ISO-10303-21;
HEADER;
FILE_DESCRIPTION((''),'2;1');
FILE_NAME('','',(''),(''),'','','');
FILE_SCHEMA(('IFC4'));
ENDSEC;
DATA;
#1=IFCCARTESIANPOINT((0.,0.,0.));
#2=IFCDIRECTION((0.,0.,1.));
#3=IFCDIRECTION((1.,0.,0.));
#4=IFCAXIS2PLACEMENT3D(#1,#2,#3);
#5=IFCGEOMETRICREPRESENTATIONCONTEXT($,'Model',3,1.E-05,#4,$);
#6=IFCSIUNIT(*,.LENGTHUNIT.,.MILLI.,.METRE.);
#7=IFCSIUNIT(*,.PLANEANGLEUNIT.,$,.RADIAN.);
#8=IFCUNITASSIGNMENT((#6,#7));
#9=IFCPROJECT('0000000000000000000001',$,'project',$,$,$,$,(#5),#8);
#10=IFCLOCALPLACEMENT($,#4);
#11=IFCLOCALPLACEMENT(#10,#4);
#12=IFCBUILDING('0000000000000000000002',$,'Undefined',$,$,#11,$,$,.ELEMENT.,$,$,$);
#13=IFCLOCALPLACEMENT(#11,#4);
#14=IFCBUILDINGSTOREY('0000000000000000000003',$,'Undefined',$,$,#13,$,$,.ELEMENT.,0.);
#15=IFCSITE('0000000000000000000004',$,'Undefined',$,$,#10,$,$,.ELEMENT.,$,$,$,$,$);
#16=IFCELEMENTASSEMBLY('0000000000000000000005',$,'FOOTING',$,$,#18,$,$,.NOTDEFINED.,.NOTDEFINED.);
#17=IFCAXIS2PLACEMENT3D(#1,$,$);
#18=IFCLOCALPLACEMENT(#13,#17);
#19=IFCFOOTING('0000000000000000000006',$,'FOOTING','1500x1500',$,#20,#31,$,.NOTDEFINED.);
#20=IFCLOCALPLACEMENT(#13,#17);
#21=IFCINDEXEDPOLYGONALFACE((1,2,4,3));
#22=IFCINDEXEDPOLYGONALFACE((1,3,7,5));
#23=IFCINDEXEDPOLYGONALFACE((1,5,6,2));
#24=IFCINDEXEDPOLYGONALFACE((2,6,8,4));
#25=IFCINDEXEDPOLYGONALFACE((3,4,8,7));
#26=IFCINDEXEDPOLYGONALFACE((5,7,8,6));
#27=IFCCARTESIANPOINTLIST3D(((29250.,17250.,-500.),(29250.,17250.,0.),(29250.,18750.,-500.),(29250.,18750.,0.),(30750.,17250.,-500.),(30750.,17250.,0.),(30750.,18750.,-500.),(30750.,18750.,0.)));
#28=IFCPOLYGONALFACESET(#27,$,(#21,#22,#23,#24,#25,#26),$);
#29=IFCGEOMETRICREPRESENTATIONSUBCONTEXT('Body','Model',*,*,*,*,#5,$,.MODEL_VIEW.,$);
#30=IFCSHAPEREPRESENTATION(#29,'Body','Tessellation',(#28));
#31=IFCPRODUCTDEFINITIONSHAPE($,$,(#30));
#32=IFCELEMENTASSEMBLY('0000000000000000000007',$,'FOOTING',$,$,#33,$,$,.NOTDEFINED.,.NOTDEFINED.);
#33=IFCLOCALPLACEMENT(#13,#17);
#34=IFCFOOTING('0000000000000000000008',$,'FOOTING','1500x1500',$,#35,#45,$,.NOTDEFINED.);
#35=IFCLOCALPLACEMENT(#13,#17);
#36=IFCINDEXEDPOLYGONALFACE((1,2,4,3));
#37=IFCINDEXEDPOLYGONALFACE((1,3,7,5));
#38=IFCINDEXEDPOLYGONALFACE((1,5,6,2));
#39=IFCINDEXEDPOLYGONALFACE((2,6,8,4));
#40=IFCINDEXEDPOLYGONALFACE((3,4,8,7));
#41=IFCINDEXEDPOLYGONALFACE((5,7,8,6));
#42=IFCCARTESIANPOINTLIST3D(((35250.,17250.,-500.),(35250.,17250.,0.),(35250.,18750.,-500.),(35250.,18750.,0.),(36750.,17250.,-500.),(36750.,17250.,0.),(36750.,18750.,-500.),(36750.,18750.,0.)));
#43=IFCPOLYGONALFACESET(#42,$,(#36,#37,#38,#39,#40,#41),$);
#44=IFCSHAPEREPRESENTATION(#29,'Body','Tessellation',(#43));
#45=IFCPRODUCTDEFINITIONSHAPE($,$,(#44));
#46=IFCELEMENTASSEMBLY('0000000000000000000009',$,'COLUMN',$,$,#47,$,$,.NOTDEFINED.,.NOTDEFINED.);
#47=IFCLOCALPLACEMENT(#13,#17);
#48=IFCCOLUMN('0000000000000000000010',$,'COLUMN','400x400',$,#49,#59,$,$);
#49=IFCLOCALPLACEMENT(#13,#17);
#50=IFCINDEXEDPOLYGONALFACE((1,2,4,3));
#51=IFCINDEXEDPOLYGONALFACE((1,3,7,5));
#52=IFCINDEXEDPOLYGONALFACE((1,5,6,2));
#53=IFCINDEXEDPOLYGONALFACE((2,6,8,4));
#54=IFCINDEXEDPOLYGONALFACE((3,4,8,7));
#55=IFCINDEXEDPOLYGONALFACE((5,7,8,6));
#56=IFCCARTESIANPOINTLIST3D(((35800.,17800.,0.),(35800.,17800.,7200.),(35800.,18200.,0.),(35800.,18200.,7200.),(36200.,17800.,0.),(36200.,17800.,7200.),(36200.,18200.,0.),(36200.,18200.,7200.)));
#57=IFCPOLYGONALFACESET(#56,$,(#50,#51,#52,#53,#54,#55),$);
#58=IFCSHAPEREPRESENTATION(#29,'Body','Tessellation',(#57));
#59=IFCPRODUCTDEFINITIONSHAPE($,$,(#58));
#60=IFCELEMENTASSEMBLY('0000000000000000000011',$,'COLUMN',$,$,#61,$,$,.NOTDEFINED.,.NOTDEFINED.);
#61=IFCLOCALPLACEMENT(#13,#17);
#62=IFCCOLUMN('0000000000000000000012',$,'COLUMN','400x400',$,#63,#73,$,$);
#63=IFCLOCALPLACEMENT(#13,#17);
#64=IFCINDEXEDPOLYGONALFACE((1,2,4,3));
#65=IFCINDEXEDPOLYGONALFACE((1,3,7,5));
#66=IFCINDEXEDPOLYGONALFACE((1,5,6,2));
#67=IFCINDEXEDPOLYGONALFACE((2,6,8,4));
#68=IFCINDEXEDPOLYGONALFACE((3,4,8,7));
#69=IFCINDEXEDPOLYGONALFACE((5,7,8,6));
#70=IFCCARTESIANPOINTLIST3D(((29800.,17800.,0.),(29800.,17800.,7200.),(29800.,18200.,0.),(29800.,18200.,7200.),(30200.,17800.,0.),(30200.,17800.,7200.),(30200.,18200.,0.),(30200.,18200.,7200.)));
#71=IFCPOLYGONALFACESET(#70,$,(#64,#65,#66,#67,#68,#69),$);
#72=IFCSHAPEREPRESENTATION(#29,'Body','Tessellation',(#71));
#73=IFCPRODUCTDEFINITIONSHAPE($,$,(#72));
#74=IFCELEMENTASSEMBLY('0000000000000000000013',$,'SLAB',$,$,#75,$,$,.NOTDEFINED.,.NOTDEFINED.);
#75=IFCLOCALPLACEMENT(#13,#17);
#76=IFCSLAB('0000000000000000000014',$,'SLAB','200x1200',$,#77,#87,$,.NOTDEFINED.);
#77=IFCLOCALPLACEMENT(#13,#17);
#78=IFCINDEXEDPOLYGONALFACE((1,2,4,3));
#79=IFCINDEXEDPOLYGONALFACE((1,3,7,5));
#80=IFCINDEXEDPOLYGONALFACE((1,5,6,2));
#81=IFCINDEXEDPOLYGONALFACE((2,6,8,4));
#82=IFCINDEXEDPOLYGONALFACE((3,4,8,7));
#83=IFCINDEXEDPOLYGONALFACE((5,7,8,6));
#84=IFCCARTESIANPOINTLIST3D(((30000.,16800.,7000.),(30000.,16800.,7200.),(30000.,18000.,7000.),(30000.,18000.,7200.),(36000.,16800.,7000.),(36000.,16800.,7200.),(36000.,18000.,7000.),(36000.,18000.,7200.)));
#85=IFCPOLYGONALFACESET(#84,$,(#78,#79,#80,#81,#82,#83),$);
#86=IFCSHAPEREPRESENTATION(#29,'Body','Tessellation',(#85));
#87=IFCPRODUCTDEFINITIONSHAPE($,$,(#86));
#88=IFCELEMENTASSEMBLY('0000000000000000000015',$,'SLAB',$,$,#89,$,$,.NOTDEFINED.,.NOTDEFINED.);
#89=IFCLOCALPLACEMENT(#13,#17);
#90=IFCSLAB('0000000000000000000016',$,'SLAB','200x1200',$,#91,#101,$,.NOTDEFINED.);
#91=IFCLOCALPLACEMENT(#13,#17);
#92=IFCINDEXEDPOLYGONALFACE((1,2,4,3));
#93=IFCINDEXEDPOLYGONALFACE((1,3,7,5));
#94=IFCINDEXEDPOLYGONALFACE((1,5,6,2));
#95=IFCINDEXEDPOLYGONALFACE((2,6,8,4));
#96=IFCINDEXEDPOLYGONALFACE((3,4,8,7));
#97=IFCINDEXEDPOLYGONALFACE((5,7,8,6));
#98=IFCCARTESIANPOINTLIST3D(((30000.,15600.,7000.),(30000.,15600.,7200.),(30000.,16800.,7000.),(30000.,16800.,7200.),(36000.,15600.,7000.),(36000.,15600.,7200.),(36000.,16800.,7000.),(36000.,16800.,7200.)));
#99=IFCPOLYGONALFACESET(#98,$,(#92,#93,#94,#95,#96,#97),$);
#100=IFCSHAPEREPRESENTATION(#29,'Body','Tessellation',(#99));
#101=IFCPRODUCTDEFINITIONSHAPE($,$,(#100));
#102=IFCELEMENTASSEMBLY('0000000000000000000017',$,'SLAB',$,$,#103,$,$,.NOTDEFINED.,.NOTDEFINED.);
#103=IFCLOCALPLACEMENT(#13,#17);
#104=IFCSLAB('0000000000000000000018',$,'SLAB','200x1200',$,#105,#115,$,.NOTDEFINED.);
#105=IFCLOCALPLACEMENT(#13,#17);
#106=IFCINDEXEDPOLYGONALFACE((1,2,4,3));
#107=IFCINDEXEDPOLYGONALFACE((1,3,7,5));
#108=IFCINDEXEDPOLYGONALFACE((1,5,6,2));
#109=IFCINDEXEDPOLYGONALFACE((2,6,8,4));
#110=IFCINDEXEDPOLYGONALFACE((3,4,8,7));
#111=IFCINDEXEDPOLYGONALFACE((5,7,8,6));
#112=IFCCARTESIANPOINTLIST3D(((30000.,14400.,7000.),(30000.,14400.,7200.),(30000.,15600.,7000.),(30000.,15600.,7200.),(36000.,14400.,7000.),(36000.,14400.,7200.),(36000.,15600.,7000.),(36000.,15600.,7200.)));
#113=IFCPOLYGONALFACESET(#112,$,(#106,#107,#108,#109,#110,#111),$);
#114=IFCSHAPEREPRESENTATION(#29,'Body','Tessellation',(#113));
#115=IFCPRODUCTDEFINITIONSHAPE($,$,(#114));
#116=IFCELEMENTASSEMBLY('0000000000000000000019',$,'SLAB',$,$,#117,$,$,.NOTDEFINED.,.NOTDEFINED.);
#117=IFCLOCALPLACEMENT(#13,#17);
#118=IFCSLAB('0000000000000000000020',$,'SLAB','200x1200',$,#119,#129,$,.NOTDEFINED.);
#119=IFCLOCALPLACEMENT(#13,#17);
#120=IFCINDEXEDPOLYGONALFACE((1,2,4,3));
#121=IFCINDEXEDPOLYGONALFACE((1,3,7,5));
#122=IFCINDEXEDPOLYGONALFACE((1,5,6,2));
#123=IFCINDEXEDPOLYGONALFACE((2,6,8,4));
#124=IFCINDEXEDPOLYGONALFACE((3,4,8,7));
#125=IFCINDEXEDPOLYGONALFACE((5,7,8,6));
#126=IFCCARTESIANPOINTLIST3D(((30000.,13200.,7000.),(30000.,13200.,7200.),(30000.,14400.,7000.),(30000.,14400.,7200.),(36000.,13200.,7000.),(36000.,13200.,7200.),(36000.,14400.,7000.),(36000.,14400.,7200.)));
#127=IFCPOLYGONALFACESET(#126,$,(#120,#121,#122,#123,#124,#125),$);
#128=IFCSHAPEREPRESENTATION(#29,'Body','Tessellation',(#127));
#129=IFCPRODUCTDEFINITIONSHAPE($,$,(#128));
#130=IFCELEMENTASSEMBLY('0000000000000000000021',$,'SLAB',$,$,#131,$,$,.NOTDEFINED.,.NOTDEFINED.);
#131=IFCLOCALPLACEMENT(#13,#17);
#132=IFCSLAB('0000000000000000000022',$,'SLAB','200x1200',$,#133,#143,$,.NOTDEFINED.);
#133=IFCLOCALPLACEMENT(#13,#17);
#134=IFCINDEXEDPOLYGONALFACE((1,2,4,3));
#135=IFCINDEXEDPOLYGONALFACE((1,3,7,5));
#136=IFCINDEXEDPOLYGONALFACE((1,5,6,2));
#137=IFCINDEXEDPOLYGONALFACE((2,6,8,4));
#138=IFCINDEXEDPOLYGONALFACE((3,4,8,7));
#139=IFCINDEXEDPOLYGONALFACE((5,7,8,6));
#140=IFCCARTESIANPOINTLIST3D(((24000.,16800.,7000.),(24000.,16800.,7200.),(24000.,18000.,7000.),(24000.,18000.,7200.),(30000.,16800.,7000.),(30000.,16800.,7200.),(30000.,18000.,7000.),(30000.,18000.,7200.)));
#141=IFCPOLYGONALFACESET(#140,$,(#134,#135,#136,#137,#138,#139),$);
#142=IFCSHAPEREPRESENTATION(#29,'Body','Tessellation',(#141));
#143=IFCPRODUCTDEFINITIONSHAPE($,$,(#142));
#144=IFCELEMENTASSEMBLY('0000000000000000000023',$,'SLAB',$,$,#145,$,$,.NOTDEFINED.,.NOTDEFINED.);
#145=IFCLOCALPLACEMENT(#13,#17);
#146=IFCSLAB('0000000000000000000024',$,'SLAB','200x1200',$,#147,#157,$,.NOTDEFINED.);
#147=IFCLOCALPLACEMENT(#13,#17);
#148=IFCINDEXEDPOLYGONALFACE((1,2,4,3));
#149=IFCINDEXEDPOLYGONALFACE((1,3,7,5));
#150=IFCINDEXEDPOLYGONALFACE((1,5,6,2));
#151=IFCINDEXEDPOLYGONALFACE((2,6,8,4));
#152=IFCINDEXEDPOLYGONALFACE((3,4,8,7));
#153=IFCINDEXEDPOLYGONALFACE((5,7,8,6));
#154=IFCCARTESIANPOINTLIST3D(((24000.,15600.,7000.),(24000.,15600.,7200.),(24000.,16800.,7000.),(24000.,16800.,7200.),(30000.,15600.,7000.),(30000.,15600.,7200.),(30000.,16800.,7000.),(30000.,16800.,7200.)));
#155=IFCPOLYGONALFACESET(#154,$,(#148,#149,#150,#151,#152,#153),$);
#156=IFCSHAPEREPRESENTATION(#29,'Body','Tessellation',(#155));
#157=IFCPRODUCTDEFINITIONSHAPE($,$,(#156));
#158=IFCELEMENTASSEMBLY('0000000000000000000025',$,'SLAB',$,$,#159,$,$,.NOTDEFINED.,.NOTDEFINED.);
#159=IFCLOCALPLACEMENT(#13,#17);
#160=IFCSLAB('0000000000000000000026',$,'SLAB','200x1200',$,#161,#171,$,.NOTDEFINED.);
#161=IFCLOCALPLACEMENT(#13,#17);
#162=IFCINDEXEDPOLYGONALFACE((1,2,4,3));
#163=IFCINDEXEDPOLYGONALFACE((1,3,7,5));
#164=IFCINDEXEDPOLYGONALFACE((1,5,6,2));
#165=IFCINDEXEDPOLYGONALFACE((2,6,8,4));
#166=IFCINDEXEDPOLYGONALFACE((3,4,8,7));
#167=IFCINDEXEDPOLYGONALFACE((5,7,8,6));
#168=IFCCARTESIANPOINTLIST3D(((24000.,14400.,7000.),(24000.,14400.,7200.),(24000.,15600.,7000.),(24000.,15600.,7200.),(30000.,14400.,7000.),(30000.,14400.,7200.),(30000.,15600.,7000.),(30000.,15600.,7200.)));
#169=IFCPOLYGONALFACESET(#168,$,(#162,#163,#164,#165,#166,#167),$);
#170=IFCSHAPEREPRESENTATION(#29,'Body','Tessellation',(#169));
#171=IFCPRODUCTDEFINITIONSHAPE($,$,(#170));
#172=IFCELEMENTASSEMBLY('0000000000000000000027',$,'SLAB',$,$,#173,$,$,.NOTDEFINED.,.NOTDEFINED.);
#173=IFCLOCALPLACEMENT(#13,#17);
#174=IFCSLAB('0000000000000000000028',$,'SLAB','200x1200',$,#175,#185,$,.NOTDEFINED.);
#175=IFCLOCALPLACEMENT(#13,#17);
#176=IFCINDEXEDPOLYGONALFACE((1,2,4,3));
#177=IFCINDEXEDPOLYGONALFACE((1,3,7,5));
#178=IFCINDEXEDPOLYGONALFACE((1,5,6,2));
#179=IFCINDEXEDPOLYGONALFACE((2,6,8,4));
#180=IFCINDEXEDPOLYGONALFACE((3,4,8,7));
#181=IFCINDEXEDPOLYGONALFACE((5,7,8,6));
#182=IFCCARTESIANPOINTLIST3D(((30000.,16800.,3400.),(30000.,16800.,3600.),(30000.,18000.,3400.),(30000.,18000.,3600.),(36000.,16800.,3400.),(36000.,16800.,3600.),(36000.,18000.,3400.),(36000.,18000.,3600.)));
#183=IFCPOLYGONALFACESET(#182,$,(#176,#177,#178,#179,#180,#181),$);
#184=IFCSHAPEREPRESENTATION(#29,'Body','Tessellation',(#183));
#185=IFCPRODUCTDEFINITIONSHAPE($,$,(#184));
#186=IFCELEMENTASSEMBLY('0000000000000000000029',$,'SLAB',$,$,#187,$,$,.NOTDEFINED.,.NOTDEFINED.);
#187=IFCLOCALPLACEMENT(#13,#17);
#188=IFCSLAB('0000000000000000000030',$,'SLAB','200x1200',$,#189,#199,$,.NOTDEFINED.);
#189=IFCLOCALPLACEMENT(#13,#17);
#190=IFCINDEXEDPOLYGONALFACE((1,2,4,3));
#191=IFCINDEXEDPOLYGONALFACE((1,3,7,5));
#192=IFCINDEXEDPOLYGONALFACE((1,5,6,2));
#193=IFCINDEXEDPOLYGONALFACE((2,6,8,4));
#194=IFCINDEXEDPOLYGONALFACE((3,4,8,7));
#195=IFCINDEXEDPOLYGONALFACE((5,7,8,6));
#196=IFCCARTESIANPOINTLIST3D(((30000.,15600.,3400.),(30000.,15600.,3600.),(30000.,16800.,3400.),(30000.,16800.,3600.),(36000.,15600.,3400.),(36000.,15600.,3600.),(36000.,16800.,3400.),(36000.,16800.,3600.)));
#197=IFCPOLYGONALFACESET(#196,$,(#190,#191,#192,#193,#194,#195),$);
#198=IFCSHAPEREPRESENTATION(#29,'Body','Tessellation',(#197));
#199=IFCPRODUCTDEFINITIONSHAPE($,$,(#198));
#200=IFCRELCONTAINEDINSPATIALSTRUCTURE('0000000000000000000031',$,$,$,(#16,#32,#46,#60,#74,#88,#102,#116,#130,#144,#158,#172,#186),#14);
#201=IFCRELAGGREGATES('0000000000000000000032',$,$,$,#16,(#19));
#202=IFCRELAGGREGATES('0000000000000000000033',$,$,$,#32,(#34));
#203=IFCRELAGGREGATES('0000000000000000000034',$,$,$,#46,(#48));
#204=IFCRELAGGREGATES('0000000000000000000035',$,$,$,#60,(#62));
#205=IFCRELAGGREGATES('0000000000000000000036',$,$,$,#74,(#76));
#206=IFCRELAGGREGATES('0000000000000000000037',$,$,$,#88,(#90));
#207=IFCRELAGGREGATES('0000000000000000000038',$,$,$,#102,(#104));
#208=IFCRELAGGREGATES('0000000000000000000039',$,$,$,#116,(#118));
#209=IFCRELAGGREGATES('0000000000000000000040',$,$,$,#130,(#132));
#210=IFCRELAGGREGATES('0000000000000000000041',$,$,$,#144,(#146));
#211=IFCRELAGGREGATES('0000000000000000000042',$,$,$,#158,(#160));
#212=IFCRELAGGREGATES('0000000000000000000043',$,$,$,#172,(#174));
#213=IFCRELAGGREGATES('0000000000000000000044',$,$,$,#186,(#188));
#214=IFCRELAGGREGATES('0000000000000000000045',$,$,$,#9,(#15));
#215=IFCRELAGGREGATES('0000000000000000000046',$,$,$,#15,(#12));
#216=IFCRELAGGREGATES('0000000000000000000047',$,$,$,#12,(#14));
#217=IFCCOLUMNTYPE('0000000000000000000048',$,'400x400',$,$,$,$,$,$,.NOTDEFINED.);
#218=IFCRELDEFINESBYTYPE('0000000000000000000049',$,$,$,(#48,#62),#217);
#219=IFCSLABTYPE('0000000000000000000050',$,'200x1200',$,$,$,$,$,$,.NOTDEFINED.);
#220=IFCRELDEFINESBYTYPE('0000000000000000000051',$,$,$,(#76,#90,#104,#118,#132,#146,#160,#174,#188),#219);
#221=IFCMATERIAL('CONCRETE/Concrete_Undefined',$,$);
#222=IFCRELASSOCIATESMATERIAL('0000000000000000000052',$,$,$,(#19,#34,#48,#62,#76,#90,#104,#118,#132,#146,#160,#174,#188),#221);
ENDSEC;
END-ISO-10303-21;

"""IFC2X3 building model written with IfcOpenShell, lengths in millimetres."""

from ifc_helpers import new_model, si_unit, frame, origin_with_axes, origin_2d_with_axis, place, context, subcontext, project, spatial, polyline, rectangle, outline, extrude, material, type_object, element, aggregate, save


model = new_model("IFC2X3")

# Units and contexts
model_context = context("Model", 3, precision=1e-05, world=origin_with_axes())
body_context = subcontext(model_context, "Body", "Model", "MODEL_VIEW")
ifc_project = project(units=[si_unit("LENGTHUNIT", "METRE", prefix="MILLI"), si_unit("PLANEANGLEUNIT", "RADIAN")], contexts=[model_context])

# Site, building, storey
site_placement = place(None, origin_with_axes())
site = spatial("IfcSite", under=ifc_project, at=site_placement, Name="Undefined", CompositionType="ELEMENT")
building_placement = place(site_placement, origin_with_axes())
building = spatial("IfcBuilding", under=site, at=building_placement, Name="Undefined", CompositionType="ELEMENT")
storey_placement = place(building_placement, origin_with_axes())
storey = spatial("IfcBuildingStorey", under=building, at=storey_placement, Name="Undefined", CompositionType="ELEMENT", Elevation=0.0)

# Element assemblies, footings
assembly_1_placement = place(storey_placement, origin_with_axes())
assembly_1 = element("IfcElementAssembly", 1, at=assembly_1_placement, inside=storey, Name="FOOTING", AssemblyPlace="NOTDEFINED", PredefinedType="NOTDEFINED")
ifc_material = material(Name="CONCRETE/Concrete_Undefined")
footing_1_placement = place(assembly_1_placement, frame((30000.0, 18000.0, -500.0), z_axis=(0.0, 1.0, 0.0), x_axis=(0.0, 0.0, 1.0)))
footing_1 = element("IfcFooting", 2, at=footing_1_placement, material=ifc_material, Name="FOOTING", Description="1500x1500", PredefinedType="NOTDEFINED", context=body_context, shape_type="SweptSolid", body=[
    extrude(rectangle(XDim=1500.0, YDim=1500.0, at=origin_2d_with_axis()), frame((500.0, 0.0, 0.0), z_axis=(-1.0, 0.0, 0.0), x_axis=(0.0, -1.0, 0.0)), (0.0, 0.0, 1.0), 500.0),
])
aggregate(assembly_1, [footing_1])
assembly_2_placement = place(storey_placement, origin_with_axes())
assembly_2 = element("IfcElementAssembly", 3, at=assembly_2_placement, inside=storey, Name="FOOTING", AssemblyPlace="NOTDEFINED", PredefinedType="NOTDEFINED")
footing_2_placement = place(assembly_2_placement, frame((36000.0, 18000.0, -500.0), z_axis=(0.0, 1.0, 0.0), x_axis=(0.0, 0.0, 1.0)))
footing_2 = element("IfcFooting", 4, at=footing_2_placement, material=ifc_material, Name="FOOTING", Description="1500x1500", PredefinedType="NOTDEFINED", context=body_context, shape_type="SweptSolid", body=[
    extrude(rectangle(XDim=1500.0, YDim=1500.0, at=origin_2d_with_axis()), frame((500.0, 0.0, 0.0), z_axis=(-1.0, 0.0, 0.0), x_axis=(0.0, -1.0, 0.0)), (0.0, 0.0, 1.0), 500.0),
])
aggregate(assembly_2, [footing_2])

# Element assemblies, columns
assembly_3_placement = place(storey_placement, origin_with_axes())
assembly_3 = element("IfcElementAssembly", 5, at=assembly_3_placement, inside=storey, Name="COLUMN", AssemblyPlace="NOTDEFINED", PredefinedType="NOTDEFINED")
column_type = type_object("IfcColumnType", Name="400x400", PredefinedType="NOTDEFINED")
column_1_placement = place(assembly_3_placement, frame((36000.0, 18000.0, 0.0), z_axis=(0.0, 0.0, 1.0), x_axis=(0.0, 1.0, 0.0)))
column_1 = element("IfcColumn", 6, at=column_1_placement, type_object=column_type, material=ifc_material, Name="COLUMN", Description="400x400", context=body_context, shape_type="SweptSolid", body=[
    extrude(rectangle(XDim=400.0, YDim=400.0, at=origin_2d_with_axis()), frame((0.0, 0.0, 7200.0), z_axis=(0.0, 0.0, -1.0), x_axis=(0.0, 1.0, 0.0)), (0.0, 0.0, 1.0), 7200.0),
])
aggregate(assembly_3, [column_1])
assembly_4_placement = place(storey_placement, origin_with_axes())
assembly_4 = element("IfcElementAssembly", 7, at=assembly_4_placement, inside=storey, Name="COLUMN", AssemblyPlace="NOTDEFINED", PredefinedType="NOTDEFINED")
column_2_placement = place(assembly_4_placement, frame((30000.0, 18000.0, 0.0), z_axis=(0.0, 0.0, 1.0), x_axis=(0.0, 1.0, 0.0)))
column_2 = element("IfcColumn", 8, at=column_2_placement, type_object=column_type, material=ifc_material, Name="COLUMN", Description="400x400", context=body_context, shape_type="SweptSolid", body=[
    extrude(rectangle(XDim=400.0, YDim=400.0, at=origin_2d_with_axis()), frame((0.0, 0.0, 7200.0), z_axis=(0.0, 0.0, -1.0), x_axis=(0.0, 1.0, 0.0)), (0.0, 0.0, 1.0), 7200.0),
])
aggregate(assembly_4, [column_2])

# Element assemblies, slabs
assembly_5_placement = place(storey_placement, origin_with_axes())
assembly_5 = element("IfcElementAssembly", 9, at=assembly_5_placement, inside=storey, Name="SLAB", AssemblyPlace="NOTDEFINED", PredefinedType="NOTDEFINED")
slab_type = type_object("IfcSlabType", Name="200x1200", PredefinedType="NOTDEFINED")
slab_1_placement = place(assembly_5_placement, frame((36000.0, 16800.0, 7100.0), z_axis=(0.0, 0.0, 1.0), x_axis=(0.0, 1.0, 0.0)))
slab_1 = element("IfcSlab", 10, at=slab_1_placement, type_object=slab_type, material=ifc_material, Name="SLAB", Description="200x1200", PredefinedType="NOTDEFINED", context=body_context, shape_type="SweptSolid", body=[
    extrude(outline(polyline([(0.0, 0.0), (1200.0, 0.0), (1200.0, 6000.0), (0.0, 6000.0), (0.0, 0.0)])), frame((0.0, 0.0, -100.0), z_axis=(0.0, 0.0, 1.0), x_axis=(1.0, 0.0, 0.0)), (0.0, 0.0, 1.0), 200.0),
])
aggregate(assembly_5, [slab_1])
assembly_6_placement = place(storey_placement, origin_with_axes())
assembly_6 = element("IfcElementAssembly", 11, at=assembly_6_placement, inside=storey, Name="SLAB", AssemblyPlace="NOTDEFINED", PredefinedType="NOTDEFINED")
slab_2_placement = place(assembly_6_placement, frame((36000.0, 15600.0, 7100.0), z_axis=(0.0, 0.0, 1.0), x_axis=(0.0, 1.0, 0.0)))
slab_2 = element("IfcSlab", 12, at=slab_2_placement, type_object=slab_type, material=ifc_material, Name="SLAB", Description="200x1200", PredefinedType="NOTDEFINED", context=body_context, shape_type="SweptSolid", body=[
    extrude(outline(polyline([(0.0, 0.0), (1200.0, 0.0), (1200.0, 6000.0), (0.0, 6000.0), (0.0, 0.0)])), frame((0.0, 0.0, -100.0), z_axis=(0.0, 0.0, 1.0), x_axis=(1.0, 0.0, 0.0)), (0.0, 0.0, 1.0), 200.0),
])
aggregate(assembly_6, [slab_2])
assembly_7_placement = place(storey_placement, origin_with_axes())
assembly_7 = element("IfcElementAssembly", 13, at=assembly_7_placement, inside=storey, Name="SLAB", AssemblyPlace="NOTDEFINED", PredefinedType="NOTDEFINED")
slab_3_placement = place(assembly_7_placement, frame((36000.0, 14400.0, 7100.0), z_axis=(0.0, 0.0, 1.0), x_axis=(0.0, 1.0, 0.0)))
slab_3 = element("IfcSlab", 14, at=slab_3_placement, type_object=slab_type, material=ifc_material, Name="SLAB", Description="200x1200", PredefinedType="NOTDEFINED", context=body_context, shape_type="SweptSolid", body=[
    extrude(outline(polyline([(0.0, 0.0), (1200.0, 0.0), (1200.0, 6000.0), (0.0, 6000.0), (0.0, 0.0)])), frame((0.0, 0.0, -100.0), z_axis=(0.0, 0.0, 1.0), x_axis=(1.0, 0.0, 0.0)), (0.0, 0.0, 1.0), 200.0),
])
aggregate(assembly_7, [slab_3])
assembly_8_placement = place(storey_placement, origin_with_axes())
assembly_8 = element("IfcElementAssembly", 15, at=assembly_8_placement, inside=storey, Name="SLAB", AssemblyPlace="NOTDEFINED", PredefinedType="NOTDEFINED")
slab_4_placement = place(assembly_8_placement, frame((36000.0, 13200.0, 7100.0), z_axis=(0.0, 0.0, 1.0), x_axis=(0.0, 1.0, 0.0)))
slab_4 = element("IfcSlab", 16, at=slab_4_placement, type_object=slab_type, material=ifc_material, Name="SLAB", Description="200x1200", PredefinedType="NOTDEFINED", context=body_context, shape_type="SweptSolid", body=[
    extrude(outline(polyline([(0.0, 0.0), (1200.0, 0.0), (1200.0, 6000.0), (0.0, 6000.0), (0.0, 0.0)])), frame((0.0, 0.0, -100.0), z_axis=(0.0, 0.0, 1.0), x_axis=(1.0, 0.0, 0.0)), (0.0, 0.0, 1.0), 200.0),
])
aggregate(assembly_8, [slab_4])
assembly_9_placement = place(storey_placement, origin_with_axes())
assembly_9 = element("IfcElementAssembly", 17, at=assembly_9_placement, inside=storey, Name="SLAB", AssemblyPlace="NOTDEFINED", PredefinedType="NOTDEFINED")
slab_5_placement = place(assembly_9_placement, frame((30000.0, 16800.0, 7100.0), z_axis=(0.0, 0.0, 1.0), x_axis=(0.0, 1.0, 0.0)))
slab_5 = element("IfcSlab", 18, at=slab_5_placement, type_object=slab_type, material=ifc_material, Name="SLAB", Description="200x1200", PredefinedType="NOTDEFINED", context=body_context, shape_type="SweptSolid", body=[
    extrude(outline(polyline([(0.0, 0.0), (1200.0, 0.0), (1200.0, 6000.0), (0.0, 6000.0), (0.0, 0.0)])), frame((0.0, 0.0, -100.0), z_axis=(0.0, 0.0, 1.0), x_axis=(1.0, 0.0, 0.0)), (0.0, 0.0, 1.0), 200.0),
])
aggregate(assembly_9, [slab_5])
assembly_10_placement = place(storey_placement, origin_with_axes())
assembly_10 = element("IfcElementAssembly", 19, at=assembly_10_placement, inside=storey, Name="SLAB", AssemblyPlace="NOTDEFINED", PredefinedType="NOTDEFINED")
slab_6_placement = place(assembly_10_placement, frame((30000.0, 15600.0, 7100.0), z_axis=(0.0, 0.0, 1.0), x_axis=(0.0, 1.0, 0.0)))
slab_6 = element("IfcSlab", 20, at=slab_6_placement, type_object=slab_type, material=ifc_material, Name="SLAB", Description="200x1200", PredefinedType="NOTDEFINED", context=body_context, shape_type="SweptSolid", body=[
    extrude(outline(polyline([(0.0, 0.0), (1200.0, 0.0), (1200.0, 6000.0), (0.0, 6000.0), (0.0, 0.0)])), frame((0.0, 0.0, -100.0), z_axis=(0.0, 0.0, 1.0), x_axis=(1.0, 0.0, 0.0)), (0.0, 0.0, 1.0), 200.0),
])
aggregate(assembly_10, [slab_6])
assembly_11_placement = place(storey_placement, origin_with_axes())
assembly_11 = element("IfcElementAssembly", 21, at=assembly_11_placement, inside=storey, Name="SLAB", AssemblyPlace="NOTDEFINED", PredefinedType="NOTDEFINED")
slab_7_placement = place(assembly_11_placement, frame((30000.0, 14400.0, 7100.0), z_axis=(0.0, 0.0, 1.0), x_axis=(0.0, 1.0, 0.0)))
slab_7 = element("IfcSlab", 22, at=slab_7_placement, type_object=slab_type, material=ifc_material, Name="SLAB", Description="200x1200", PredefinedType="NOTDEFINED", context=body_context, shape_type="SweptSolid", body=[
    extrude(outline(polyline([(0.0, 0.0), (1200.0, 0.0), (1200.0, 6000.0), (0.0, 6000.0), (0.0, 0.0)])), frame((0.0, 0.0, -100.0), z_axis=(0.0, 0.0, 1.0), x_axis=(1.0, 0.0, 0.0)), (0.0, 0.0, 1.0), 200.0),
])
aggregate(assembly_11, [slab_7])
assembly_12_placement = place(storey_placement, origin_with_axes())
assembly_12 = element("IfcElementAssembly", 23, at=assembly_12_placement, inside=storey, Name="SLAB", AssemblyPlace="NOTDEFINED", PredefinedType="NOTDEFINED")
slab_8_placement = place(assembly_12_placement, frame((36000.0, 16800.0, 3500.0), z_axis=(0.0, 0.0, 1.0), x_axis=(0.0, 1.0, 0.0)))
slab_8 = element("IfcSlab", 24, at=slab_8_placement, type_object=slab_type, material=ifc_material, Name="SLAB", Description="200x1200", PredefinedType="NOTDEFINED", context=body_context, shape_type="SweptSolid", body=[
    extrude(outline(polyline([(0.0, 0.0), (1200.0, 0.0), (1200.0, 6000.0), (0.0, 6000.0), (0.0, 0.0)])), frame((0.0, 0.0, -100.0), z_axis=(0.0, 0.0, 1.0), x_axis=(1.0, 0.0, 0.0)), (0.0, 0.0, 1.0), 200.0),
])
aggregate(assembly_12, [slab_8])
assembly_13_placement = place(storey_placement, origin_with_axes())
assembly_13 = element("IfcElementAssembly", 25, at=assembly_13_placement, inside=storey, Name="SLAB", AssemblyPlace="NOTDEFINED", PredefinedType="NOTDEFINED")
slab_9_placement = place(assembly_13_placement, frame((36000.0, 15600.0, 3500.0), z_axis=(0.0, 0.0, 1.0), x_axis=(0.0, 1.0, 0.0)))
slab_9 = element("IfcSlab", 26, at=slab_9_placement, type_object=slab_type, material=ifc_material, Name="SLAB", Description="200x1200", PredefinedType="NOTDEFINED", context=body_context, shape_type="SweptSolid", body=[
    extrude(outline(polyline([(0.0, 0.0), (1200.0, 0.0), (1200.0, 6000.0), (0.0, 6000.0), (0.0, 0.0)])), frame((0.0, 0.0, -100.0), z_axis=(0.0, 0.0, 1.0), x_axis=(1.0, 0.0, 0.0)), (0.0, 0.0, 1.0), 200.0),
])
aggregate(assembly_13, [slab_9])

save(model, "model.ifc")
